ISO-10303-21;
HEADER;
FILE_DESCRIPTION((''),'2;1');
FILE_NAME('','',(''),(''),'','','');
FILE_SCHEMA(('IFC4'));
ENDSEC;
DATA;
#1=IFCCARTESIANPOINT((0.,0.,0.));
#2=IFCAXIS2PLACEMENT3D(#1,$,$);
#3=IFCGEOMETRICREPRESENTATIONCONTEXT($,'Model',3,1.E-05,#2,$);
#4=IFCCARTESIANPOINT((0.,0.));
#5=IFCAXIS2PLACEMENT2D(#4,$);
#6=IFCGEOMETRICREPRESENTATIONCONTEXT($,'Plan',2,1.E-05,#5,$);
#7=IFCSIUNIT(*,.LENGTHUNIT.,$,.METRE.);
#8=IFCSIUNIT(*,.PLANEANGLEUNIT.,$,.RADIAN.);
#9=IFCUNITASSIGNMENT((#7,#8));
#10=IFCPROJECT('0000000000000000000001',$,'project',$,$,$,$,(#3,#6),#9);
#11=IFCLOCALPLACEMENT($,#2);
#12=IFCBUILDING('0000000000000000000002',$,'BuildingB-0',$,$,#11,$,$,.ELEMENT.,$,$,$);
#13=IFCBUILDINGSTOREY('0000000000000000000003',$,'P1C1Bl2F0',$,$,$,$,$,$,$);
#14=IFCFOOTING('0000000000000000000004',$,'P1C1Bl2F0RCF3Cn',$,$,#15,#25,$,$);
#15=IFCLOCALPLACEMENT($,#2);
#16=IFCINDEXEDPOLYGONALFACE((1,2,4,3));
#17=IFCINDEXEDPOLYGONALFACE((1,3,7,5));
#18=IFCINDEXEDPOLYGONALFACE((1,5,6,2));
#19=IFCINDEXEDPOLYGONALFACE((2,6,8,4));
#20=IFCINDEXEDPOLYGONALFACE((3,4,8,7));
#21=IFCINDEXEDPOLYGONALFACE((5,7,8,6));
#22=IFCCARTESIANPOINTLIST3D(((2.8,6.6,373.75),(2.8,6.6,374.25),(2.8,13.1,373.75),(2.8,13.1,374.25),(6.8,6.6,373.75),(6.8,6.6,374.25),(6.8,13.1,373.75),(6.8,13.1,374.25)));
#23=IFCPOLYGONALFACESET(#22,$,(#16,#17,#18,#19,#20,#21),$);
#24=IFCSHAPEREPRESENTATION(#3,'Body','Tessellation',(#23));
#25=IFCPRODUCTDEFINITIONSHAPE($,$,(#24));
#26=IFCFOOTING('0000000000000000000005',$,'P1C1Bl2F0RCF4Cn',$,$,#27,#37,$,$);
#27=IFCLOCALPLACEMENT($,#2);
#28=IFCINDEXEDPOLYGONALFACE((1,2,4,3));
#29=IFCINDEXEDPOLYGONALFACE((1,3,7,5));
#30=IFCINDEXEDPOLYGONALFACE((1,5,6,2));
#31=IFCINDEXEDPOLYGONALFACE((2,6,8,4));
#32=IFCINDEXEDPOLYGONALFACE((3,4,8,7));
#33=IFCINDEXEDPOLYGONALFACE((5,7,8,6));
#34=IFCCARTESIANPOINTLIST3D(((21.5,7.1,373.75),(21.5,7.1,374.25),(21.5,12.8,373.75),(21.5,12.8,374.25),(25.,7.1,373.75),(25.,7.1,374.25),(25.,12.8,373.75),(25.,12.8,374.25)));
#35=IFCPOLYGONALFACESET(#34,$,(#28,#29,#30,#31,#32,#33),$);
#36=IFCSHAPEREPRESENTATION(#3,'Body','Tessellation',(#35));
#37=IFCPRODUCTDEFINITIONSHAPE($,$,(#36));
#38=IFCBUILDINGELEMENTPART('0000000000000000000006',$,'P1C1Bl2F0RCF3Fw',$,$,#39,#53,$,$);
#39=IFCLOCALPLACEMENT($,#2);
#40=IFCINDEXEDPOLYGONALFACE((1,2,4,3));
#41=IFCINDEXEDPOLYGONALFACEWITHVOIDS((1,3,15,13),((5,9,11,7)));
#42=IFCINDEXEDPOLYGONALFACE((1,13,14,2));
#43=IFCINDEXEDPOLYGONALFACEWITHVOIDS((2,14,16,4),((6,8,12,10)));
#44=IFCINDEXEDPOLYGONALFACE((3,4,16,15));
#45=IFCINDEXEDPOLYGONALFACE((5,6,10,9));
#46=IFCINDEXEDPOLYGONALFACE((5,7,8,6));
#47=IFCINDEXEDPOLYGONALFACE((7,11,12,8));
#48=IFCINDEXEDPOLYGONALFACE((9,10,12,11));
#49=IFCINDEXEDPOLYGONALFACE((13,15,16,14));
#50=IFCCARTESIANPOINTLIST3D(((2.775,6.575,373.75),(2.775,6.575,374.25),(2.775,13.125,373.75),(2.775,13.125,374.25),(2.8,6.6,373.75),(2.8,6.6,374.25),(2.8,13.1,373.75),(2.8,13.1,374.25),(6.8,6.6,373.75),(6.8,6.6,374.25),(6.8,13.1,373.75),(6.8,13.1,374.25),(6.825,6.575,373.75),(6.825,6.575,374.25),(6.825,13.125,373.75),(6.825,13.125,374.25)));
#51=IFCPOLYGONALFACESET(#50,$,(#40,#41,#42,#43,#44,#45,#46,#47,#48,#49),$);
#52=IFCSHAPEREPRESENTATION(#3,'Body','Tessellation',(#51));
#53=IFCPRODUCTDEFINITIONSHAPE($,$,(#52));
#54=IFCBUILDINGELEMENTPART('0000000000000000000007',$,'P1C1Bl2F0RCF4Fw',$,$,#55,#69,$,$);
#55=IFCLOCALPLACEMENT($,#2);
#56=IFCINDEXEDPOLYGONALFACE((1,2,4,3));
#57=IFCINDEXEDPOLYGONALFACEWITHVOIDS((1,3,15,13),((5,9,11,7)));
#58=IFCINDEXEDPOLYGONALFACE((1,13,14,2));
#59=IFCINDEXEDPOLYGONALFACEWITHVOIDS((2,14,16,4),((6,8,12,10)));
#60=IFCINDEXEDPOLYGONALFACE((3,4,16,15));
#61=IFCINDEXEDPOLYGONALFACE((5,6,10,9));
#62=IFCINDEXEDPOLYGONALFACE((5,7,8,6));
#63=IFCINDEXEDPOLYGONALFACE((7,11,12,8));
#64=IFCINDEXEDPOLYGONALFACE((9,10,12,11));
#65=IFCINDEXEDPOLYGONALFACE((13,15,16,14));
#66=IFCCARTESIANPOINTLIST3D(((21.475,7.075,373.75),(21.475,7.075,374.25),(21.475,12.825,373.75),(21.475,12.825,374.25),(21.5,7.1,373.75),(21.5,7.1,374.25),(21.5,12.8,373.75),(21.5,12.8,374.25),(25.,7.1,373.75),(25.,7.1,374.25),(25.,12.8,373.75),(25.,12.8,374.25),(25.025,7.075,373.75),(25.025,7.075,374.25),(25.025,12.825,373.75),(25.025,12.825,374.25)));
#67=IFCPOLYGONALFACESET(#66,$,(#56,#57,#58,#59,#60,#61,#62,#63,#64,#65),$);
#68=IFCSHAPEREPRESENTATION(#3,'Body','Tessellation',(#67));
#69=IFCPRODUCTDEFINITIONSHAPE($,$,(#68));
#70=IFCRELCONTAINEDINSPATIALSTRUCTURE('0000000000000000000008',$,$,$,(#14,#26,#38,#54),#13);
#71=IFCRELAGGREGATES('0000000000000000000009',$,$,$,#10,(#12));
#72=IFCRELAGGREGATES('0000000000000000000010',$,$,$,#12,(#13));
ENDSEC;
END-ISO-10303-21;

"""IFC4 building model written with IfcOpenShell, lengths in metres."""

from ifc_helpers import new_model, si_unit, origin, origin_2d, place, context, project, spatial, polyline, outline, extrude, element, save


model = new_model("IFC4")

# Units and contexts
model_context = context("Model", 3, precision=1e-05, world=origin())
plan_context = context("Plan", 2, precision=1e-05, world=origin_2d())
ifc_project = project(units=[si_unit("LENGTHUNIT", "METRE"), si_unit("PLANEANGLEUNIT", "RADIAN")], contexts=[model_context, plan_context])

# Building, storey
building_placement = place(None, origin())
building = spatial("IfcBuilding", under=ifc_project, at=building_placement, Name="BuildingB-0", CompositionType="ELEMENT")
storey = spatial("IfcBuildingStorey", under=building, Name="P1C1Bl2F0")

# Footings
element("IfcFooting", 1, inside=storey, Name="P1C1Bl2F0RCF3Cn", context=model_context, shape_type="SweptSolid", body=[
    extrude(outline(polyline([(6.8, 13.1, 373.75), (2.8, 13.1, 373.75), (2.8, 6.6, 373.75), (6.8, 6.6, 373.75), (6.8, 13.1, 373.75)])), None, (0.0, 0.0, 1.0), 0.5),
])
element("IfcFooting", 2, inside=storey, Name="P1C1Bl2F0RCF4Cn", context=model_context, shape_type="SweptSolid", body=[
    extrude(outline(polyline([(25.0, 12.8, 373.75), (21.5, 12.8, 373.75), (21.5, 7.1, 373.75), (25.0, 7.1, 373.75), (25.0, 12.8, 373.75)])), None, (0.0, 0.0, 1.0), 0.5),
])

# Building element part, opening
building_element_part_1 = element("IfcBuildingElementPart", 3, inside=storey, Name="P1C1Bl2F0RCF3Fw", context=model_context, shape_type="SweptSolid", body=[
    extrude(outline(polyline([(6.825, 13.125, 373.75), (2.775, 13.125, 373.75), (2.775, 6.575, 373.75), (6.825, 6.575, 373.75), (6.825, 13.125, 373.75)])), None, (0.0, 0.0, 1.0), 0.5),
])
element("IfcOpeningElement", 4, inside=storey, cuts=building_element_part_1, context=model_context, shape_type="SweptSolid", body=[
    extrude(outline(polyline([(6.8, 13.1, 373.75), (2.8, 13.1, 373.75), (2.8, 6.6, 373.75), (6.8, 6.6, 373.75), (6.8, 13.1, 373.75)])), None, (0.0, 0.0, 1.0), 0.5),
])

# Building element part, opening
building_element_part_2 = element("IfcBuildingElementPart", 5, inside=storey, Name="P1C1Bl2F0RCF4Fw", context=model_context, shape_type="SweptSolid", body=[
    extrude(outline(polyline([(25.025, 12.825, 373.75), (21.475, 12.825, 373.75), (21.475, 7.075, 373.75), (25.025, 7.075, 373.75), (25.025, 12.825, 373.75)])), None, (0.0, 0.0, 1.0), 0.5),
])
element("IfcOpeningElement", 6, inside=storey, cuts=building_element_part_2, context=model_context, shape_type="SweptSolid", body=[
    extrude(outline(polyline([(25.0, 12.8, 373.75), (21.5, 12.8, 373.75), (21.5, 7.1, 373.75), (25.0, 7.1, 373.75), (25.0, 12.8, 373.75)])), None, (0.0, 0.0, 1.0), 0.5),
])

save(model, "model.ifc")
